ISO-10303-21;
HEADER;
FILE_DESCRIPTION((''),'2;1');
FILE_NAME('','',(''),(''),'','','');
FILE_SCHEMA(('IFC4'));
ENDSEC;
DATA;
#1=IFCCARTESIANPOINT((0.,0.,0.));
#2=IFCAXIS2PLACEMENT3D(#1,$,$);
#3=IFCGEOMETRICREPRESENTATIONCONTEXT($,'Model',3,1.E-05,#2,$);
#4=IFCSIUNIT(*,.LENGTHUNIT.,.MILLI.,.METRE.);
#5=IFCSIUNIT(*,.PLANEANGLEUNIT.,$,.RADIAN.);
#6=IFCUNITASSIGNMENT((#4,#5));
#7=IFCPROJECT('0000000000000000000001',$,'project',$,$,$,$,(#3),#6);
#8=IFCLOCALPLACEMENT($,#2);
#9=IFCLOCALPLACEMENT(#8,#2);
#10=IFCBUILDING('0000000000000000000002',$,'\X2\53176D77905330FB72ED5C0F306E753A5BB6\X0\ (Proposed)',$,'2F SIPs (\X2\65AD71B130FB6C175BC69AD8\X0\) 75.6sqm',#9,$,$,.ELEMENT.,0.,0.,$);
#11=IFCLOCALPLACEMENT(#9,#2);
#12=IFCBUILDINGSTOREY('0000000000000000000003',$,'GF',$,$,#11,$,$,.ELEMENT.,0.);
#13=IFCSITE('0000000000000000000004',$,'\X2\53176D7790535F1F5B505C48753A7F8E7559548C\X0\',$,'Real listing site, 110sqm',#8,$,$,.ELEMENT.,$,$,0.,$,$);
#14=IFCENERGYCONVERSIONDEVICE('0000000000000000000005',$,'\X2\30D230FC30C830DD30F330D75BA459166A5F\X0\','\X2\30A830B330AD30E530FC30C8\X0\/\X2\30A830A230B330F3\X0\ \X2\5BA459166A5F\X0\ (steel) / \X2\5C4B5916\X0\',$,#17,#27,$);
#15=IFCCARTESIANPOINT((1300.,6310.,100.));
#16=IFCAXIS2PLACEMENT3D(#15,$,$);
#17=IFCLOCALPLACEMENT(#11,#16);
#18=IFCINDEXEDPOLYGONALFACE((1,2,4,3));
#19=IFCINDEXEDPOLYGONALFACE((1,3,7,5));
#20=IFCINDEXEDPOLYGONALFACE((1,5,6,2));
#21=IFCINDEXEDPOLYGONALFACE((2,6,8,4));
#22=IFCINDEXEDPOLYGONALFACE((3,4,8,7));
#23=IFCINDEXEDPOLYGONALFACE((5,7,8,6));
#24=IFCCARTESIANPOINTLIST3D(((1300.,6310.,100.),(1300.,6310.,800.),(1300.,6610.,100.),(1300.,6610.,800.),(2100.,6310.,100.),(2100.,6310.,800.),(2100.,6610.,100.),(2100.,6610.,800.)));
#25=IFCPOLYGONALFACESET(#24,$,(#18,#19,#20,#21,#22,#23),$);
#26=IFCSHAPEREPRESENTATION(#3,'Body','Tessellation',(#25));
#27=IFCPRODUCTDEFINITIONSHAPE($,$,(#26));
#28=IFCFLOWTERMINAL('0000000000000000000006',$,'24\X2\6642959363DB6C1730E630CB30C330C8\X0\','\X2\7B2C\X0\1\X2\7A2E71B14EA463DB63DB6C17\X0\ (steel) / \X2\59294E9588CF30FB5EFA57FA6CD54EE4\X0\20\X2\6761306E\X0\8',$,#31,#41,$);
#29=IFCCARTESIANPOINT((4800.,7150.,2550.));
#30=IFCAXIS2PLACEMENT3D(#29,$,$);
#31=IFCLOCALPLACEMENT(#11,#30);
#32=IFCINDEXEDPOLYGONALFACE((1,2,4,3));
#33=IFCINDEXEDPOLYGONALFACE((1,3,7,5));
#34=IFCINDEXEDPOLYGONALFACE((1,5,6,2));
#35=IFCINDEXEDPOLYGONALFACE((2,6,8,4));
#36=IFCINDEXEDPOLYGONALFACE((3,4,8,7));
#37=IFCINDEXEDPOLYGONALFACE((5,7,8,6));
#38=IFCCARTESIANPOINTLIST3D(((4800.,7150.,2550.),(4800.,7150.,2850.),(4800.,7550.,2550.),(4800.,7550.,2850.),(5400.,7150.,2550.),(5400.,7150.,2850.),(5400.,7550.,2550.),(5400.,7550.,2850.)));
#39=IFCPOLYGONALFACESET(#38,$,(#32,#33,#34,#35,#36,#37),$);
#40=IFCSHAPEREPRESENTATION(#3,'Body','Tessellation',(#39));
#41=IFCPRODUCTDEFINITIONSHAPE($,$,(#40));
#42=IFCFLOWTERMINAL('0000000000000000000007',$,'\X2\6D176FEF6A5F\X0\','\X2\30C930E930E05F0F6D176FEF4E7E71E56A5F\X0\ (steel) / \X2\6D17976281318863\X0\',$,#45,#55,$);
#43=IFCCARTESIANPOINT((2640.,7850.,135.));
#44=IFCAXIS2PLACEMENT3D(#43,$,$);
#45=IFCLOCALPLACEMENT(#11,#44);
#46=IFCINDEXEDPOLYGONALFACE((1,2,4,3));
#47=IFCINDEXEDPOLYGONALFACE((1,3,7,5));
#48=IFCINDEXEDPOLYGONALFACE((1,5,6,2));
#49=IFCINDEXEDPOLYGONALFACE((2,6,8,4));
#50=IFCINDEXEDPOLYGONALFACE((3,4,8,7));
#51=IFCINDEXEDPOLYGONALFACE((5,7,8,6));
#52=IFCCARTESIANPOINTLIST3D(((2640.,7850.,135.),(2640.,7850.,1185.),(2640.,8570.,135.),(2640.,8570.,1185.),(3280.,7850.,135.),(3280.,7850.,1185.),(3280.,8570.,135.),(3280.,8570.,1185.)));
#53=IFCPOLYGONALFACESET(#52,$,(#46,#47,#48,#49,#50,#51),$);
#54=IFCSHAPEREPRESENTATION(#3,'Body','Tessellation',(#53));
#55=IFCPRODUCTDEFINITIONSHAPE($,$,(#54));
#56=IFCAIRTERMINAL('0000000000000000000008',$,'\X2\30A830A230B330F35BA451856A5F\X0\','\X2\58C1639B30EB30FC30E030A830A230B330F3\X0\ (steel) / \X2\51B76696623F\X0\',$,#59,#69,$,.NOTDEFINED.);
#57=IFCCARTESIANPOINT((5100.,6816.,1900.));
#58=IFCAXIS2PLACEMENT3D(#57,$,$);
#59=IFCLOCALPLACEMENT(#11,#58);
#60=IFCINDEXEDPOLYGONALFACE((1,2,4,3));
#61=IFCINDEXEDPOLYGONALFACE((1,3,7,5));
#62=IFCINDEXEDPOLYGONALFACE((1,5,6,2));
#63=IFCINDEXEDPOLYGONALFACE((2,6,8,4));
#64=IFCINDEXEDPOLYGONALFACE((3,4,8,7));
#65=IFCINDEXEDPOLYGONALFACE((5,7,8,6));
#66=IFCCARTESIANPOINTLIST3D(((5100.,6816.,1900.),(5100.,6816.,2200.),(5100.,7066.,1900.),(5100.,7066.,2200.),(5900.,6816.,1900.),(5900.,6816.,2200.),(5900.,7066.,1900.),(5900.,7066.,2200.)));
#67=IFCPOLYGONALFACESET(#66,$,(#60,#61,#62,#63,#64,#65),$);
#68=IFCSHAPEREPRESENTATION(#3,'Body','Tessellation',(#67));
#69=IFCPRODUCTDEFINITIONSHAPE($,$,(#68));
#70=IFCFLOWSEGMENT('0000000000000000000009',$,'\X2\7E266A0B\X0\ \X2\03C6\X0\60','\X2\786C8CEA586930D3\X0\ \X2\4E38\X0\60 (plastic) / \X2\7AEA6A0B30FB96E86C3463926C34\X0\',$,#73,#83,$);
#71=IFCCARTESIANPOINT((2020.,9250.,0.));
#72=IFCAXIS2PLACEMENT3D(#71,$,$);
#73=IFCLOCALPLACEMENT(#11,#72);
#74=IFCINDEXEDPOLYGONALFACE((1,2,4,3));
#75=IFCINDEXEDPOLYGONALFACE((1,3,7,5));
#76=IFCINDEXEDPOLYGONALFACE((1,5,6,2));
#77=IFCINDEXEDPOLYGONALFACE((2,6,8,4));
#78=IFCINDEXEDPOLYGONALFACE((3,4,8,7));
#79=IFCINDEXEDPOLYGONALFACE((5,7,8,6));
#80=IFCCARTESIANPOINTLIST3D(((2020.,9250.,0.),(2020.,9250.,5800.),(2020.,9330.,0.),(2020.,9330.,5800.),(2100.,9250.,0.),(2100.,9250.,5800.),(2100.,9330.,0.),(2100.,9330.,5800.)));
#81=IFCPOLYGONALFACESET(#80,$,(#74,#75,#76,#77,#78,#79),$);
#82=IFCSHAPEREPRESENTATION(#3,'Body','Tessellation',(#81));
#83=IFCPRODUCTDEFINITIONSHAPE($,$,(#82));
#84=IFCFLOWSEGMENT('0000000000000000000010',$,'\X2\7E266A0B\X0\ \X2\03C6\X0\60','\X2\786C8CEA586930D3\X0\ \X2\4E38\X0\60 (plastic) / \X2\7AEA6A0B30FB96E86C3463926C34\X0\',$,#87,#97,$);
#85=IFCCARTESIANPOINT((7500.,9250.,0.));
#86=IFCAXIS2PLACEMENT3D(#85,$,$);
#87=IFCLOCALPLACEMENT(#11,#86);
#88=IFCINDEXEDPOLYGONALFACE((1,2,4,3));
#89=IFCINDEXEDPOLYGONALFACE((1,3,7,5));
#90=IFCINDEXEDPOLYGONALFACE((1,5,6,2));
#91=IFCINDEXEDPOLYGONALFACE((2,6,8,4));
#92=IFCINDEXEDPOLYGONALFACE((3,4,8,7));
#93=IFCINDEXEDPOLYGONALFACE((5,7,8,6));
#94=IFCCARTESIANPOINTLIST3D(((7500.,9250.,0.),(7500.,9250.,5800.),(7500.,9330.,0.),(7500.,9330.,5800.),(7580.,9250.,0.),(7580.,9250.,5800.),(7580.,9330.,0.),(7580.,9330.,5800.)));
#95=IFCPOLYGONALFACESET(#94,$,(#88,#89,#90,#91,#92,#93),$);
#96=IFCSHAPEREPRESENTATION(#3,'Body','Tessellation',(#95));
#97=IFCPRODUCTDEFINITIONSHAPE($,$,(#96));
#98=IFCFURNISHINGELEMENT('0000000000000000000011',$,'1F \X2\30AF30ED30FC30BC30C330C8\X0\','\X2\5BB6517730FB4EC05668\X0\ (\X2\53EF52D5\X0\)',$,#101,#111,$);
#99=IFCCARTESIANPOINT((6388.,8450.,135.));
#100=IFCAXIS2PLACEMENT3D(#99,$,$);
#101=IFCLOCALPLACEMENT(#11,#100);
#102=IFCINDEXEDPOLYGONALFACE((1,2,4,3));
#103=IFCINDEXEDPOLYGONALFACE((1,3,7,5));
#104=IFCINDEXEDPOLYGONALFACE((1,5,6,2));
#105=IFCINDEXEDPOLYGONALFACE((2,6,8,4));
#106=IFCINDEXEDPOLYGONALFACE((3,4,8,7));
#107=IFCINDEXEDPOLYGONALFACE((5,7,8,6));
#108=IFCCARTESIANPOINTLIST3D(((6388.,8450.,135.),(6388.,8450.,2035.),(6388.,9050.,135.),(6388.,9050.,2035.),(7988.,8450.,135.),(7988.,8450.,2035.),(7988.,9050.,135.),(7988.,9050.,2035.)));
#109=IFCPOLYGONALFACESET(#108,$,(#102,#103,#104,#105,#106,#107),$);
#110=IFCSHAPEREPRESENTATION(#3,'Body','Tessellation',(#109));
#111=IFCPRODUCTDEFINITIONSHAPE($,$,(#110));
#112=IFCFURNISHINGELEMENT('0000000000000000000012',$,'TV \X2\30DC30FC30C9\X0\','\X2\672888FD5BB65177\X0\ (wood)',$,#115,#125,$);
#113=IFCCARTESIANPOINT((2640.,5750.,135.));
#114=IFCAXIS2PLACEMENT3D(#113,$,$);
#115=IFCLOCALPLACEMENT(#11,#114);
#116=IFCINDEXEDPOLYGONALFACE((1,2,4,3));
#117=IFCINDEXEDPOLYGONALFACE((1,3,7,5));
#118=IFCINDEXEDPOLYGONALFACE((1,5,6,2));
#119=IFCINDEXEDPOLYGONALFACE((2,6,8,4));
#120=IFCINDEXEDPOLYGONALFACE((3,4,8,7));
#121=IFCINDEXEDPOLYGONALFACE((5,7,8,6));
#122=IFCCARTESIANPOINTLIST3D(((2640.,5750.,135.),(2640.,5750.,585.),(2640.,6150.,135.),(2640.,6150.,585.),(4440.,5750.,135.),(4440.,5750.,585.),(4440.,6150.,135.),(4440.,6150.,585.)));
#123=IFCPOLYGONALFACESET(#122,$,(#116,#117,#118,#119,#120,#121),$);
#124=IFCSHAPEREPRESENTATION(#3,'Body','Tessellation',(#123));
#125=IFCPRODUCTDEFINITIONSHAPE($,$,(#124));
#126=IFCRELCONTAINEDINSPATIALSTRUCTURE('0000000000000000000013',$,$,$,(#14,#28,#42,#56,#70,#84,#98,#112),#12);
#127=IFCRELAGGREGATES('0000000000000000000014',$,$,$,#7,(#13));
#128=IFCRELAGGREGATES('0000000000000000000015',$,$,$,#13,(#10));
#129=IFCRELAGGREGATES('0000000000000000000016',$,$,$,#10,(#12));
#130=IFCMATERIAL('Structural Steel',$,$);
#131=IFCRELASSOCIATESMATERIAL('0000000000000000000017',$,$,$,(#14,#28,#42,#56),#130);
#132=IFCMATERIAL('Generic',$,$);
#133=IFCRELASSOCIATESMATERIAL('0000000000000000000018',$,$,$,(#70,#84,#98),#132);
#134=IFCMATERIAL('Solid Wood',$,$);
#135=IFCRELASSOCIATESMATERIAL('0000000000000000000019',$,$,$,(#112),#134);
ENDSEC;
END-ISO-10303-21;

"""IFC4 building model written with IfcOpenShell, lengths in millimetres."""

from ifc_helpers import new_model, si_unit, frame, frame_2d, origin, place, context, project, spatial, rectangle, extrude, material, element, save


model = new_model("IFC4")

# Units and contexts
model_context = context("Model", 3, precision=1e-05, world=origin())
ifc_project = project(units=[si_unit("LENGTHUNIT", "METRE", prefix="MILLI"), si_unit("PLANEANGLEUNIT", "RADIAN")], contexts=[model_context])

# Site, building, storey
site_placement = place(None, origin())
site = spatial("IfcSite", under=ifc_project, at=site_placement, Name="北海道弟子屈町美留和", ObjectType="Real listing site, 110sqm", CompositionType="ELEMENT", RefElevation=0.0)
building_placement = place(site_placement, origin())
building = spatial("IfcBuilding", under=site, at=building_placement, Name="北海道・狭小の町家 (Proposed)", ObjectType="2F SIPs (断熱・気密高) 75.6sqm", CompositionType="ELEMENT", ElevationOfRefHeight=0.0, ElevationOfTerrain=0.0)
storey_placement = place(building_placement, origin())
storey = spatial("IfcBuildingStorey", under=building, at=storey_placement, Name="GF", CompositionType="ELEMENT", Elevation=0.0)

# Shared definitions
ifc_material_1 = material(Name="Solid Wood")

# Shared definitions
ifc_material_2 = material(Name="Generic")

# Shared definitions
ifc_material_3 = material(Name="Structural Steel")

# Energy conversion device
energy_conversion_device_placement = place(storey_placement, frame((1300.0, 6310.0, 100.0)))
element("IfcEnergyConversionDevice", 1, at=energy_conversion_device_placement, inside=storey, material=ifc_material_3, Name="ヒートポンプ室外機", Description="エコキュート/エアコン 室外機 (steel) / 屋外", context=model_context, shape_type="SweptSolid", body=[
    extrude(rectangle(XDim=800.0, YDim=300.0, at=frame_2d((400.0, 150.0))), frame((1300.0, 6310.0, 100.0)), (0.0, 0.0, 1.0), 700.0),
])

# Flow terminals
flow_terminal_1_placement = place(storey_placement, frame((4800.0, 7150.0, 2550.0)))
element("IfcFlowTerminal", 2, at=flow_terminal_1_placement, inside=storey, material=ifc_material_3, Name="24時間換気ユニット", Description="第1種熱交換換気 (steel) / 天井裏・建基法令20条の8", context=model_context, shape_type="SweptSolid", body=[
    extrude(rectangle(XDim=600.0, YDim=400.0, at=frame_2d((300.0, 200.0))), frame((4800.0, 7150.0, 2550.0)), (0.0, 0.0, 1.0), 300.0),
])
flow_terminal_2_placement = place(storey_placement, frame((2640.0, 7850.0, 135.0)))
element("IfcFlowTerminal", 3, at=flow_terminal_2_placement, inside=storey, material=ifc_material_3, Name="洗濯機", Description="ドラム式洗濯乾燥機 (steel) / 洗面脱衣", context=model_context, shape_type="SweptSolid", body=[
    extrude(rectangle(XDim=640.0, YDim=720.0, at=frame_2d((320.0, 360.0))), frame((2640.0, 7850.0, 135.0)), (0.0, 0.0, 1.0), 1050.0),
])

# Air terminal
air_terminal_placement = place(storey_placement, frame((5100.0, 6816.0, 1900.0)))
element("IfcAirTerminal", 4, at=air_terminal_placement, inside=storey, material=ifc_material_3, Name="エアコン室内機", Description="壁掛ルームエアコン (steel) / 冷暖房", PredefinedType="NOTDEFINED", context=model_context, shape_type="SweptSolid", body=[
    extrude(rectangle(XDim=800.0, YDim=250.0, at=frame_2d((400.0, 125.0))), frame((5100.0, 6816.0, 1900.0)), (0.0, 0.0, 1.0), 300.0),
])

# Flow segments
flow_segment_1_placement = place(storey_placement, frame((2020.0, 9250.0, 0.0)))
element("IfcFlowSegment", 5, at=flow_segment_1_placement, inside=storey, material=ifc_material_2, Name="縦樋 φ60", Description="硬質塩ビ 丸60 (plastic) / 竪樋・雨水排水", context=model_context, shape_type="SweptSolid", body=[
    extrude(rectangle(XDim=80.0, YDim=80.0, at=frame_2d((40.0, 40.0))), frame((2020.0, 9250.0, 0.0)), (0.0, 0.0, 1.0), 5800.0),
])
flow_segment_2_placement = place(storey_placement, frame((7500.0, 9250.0, 0.0)))
element("IfcFlowSegment", 6, at=flow_segment_2_placement, inside=storey, material=ifc_material_2, Name="縦樋 φ60", Description="硬質塩ビ 丸60 (plastic) / 竪樋・雨水排水", context=model_context, shape_type="SweptSolid", body=[
    extrude(rectangle(XDim=80.0, YDim=80.0, at=frame_2d((40.0, 40.0))), frame((7500.0, 9250.0, 0.0)), (0.0, 0.0, 1.0), 5800.0),
])

# Furnishing elements
furnishing_1_placement = place(storey_placement, frame((6388.0, 8450.0, 135.0)))
element("IfcFurnishingElement", 7, at=furnishing_1_placement, inside=storey, material=ifc_material_2, Name="1F クローゼット", Description="家具・什器 (可動)", context=model_context, shape_type="SweptSolid", body=[
    extrude(rectangle(XDim=1600.0, YDim=600.0, at=frame_2d((800.0, 300.0))), frame((6388.0, 8450.0, 135.0)), (0.0, 0.0, 1.0), 1900.0),
])
furnishing_2_placement = place(storey_placement, frame((2640.0, 5750.0, 135.0)))
element("IfcFurnishingElement", 8, at=furnishing_2_placement, inside=storey, material=ifc_material_1, Name="TV ボード", Description="木製家具 (wood)", context=model_context, shape_type="SweptSolid", body=[
    extrude(rectangle(XDim=1800.0, YDim=400.0, at=frame_2d((900.0, 200.0))), frame((2640.0, 5750.0, 135.0)), (0.0, 0.0, 1.0), 450.0),
])

save(model, "model.ifc")
